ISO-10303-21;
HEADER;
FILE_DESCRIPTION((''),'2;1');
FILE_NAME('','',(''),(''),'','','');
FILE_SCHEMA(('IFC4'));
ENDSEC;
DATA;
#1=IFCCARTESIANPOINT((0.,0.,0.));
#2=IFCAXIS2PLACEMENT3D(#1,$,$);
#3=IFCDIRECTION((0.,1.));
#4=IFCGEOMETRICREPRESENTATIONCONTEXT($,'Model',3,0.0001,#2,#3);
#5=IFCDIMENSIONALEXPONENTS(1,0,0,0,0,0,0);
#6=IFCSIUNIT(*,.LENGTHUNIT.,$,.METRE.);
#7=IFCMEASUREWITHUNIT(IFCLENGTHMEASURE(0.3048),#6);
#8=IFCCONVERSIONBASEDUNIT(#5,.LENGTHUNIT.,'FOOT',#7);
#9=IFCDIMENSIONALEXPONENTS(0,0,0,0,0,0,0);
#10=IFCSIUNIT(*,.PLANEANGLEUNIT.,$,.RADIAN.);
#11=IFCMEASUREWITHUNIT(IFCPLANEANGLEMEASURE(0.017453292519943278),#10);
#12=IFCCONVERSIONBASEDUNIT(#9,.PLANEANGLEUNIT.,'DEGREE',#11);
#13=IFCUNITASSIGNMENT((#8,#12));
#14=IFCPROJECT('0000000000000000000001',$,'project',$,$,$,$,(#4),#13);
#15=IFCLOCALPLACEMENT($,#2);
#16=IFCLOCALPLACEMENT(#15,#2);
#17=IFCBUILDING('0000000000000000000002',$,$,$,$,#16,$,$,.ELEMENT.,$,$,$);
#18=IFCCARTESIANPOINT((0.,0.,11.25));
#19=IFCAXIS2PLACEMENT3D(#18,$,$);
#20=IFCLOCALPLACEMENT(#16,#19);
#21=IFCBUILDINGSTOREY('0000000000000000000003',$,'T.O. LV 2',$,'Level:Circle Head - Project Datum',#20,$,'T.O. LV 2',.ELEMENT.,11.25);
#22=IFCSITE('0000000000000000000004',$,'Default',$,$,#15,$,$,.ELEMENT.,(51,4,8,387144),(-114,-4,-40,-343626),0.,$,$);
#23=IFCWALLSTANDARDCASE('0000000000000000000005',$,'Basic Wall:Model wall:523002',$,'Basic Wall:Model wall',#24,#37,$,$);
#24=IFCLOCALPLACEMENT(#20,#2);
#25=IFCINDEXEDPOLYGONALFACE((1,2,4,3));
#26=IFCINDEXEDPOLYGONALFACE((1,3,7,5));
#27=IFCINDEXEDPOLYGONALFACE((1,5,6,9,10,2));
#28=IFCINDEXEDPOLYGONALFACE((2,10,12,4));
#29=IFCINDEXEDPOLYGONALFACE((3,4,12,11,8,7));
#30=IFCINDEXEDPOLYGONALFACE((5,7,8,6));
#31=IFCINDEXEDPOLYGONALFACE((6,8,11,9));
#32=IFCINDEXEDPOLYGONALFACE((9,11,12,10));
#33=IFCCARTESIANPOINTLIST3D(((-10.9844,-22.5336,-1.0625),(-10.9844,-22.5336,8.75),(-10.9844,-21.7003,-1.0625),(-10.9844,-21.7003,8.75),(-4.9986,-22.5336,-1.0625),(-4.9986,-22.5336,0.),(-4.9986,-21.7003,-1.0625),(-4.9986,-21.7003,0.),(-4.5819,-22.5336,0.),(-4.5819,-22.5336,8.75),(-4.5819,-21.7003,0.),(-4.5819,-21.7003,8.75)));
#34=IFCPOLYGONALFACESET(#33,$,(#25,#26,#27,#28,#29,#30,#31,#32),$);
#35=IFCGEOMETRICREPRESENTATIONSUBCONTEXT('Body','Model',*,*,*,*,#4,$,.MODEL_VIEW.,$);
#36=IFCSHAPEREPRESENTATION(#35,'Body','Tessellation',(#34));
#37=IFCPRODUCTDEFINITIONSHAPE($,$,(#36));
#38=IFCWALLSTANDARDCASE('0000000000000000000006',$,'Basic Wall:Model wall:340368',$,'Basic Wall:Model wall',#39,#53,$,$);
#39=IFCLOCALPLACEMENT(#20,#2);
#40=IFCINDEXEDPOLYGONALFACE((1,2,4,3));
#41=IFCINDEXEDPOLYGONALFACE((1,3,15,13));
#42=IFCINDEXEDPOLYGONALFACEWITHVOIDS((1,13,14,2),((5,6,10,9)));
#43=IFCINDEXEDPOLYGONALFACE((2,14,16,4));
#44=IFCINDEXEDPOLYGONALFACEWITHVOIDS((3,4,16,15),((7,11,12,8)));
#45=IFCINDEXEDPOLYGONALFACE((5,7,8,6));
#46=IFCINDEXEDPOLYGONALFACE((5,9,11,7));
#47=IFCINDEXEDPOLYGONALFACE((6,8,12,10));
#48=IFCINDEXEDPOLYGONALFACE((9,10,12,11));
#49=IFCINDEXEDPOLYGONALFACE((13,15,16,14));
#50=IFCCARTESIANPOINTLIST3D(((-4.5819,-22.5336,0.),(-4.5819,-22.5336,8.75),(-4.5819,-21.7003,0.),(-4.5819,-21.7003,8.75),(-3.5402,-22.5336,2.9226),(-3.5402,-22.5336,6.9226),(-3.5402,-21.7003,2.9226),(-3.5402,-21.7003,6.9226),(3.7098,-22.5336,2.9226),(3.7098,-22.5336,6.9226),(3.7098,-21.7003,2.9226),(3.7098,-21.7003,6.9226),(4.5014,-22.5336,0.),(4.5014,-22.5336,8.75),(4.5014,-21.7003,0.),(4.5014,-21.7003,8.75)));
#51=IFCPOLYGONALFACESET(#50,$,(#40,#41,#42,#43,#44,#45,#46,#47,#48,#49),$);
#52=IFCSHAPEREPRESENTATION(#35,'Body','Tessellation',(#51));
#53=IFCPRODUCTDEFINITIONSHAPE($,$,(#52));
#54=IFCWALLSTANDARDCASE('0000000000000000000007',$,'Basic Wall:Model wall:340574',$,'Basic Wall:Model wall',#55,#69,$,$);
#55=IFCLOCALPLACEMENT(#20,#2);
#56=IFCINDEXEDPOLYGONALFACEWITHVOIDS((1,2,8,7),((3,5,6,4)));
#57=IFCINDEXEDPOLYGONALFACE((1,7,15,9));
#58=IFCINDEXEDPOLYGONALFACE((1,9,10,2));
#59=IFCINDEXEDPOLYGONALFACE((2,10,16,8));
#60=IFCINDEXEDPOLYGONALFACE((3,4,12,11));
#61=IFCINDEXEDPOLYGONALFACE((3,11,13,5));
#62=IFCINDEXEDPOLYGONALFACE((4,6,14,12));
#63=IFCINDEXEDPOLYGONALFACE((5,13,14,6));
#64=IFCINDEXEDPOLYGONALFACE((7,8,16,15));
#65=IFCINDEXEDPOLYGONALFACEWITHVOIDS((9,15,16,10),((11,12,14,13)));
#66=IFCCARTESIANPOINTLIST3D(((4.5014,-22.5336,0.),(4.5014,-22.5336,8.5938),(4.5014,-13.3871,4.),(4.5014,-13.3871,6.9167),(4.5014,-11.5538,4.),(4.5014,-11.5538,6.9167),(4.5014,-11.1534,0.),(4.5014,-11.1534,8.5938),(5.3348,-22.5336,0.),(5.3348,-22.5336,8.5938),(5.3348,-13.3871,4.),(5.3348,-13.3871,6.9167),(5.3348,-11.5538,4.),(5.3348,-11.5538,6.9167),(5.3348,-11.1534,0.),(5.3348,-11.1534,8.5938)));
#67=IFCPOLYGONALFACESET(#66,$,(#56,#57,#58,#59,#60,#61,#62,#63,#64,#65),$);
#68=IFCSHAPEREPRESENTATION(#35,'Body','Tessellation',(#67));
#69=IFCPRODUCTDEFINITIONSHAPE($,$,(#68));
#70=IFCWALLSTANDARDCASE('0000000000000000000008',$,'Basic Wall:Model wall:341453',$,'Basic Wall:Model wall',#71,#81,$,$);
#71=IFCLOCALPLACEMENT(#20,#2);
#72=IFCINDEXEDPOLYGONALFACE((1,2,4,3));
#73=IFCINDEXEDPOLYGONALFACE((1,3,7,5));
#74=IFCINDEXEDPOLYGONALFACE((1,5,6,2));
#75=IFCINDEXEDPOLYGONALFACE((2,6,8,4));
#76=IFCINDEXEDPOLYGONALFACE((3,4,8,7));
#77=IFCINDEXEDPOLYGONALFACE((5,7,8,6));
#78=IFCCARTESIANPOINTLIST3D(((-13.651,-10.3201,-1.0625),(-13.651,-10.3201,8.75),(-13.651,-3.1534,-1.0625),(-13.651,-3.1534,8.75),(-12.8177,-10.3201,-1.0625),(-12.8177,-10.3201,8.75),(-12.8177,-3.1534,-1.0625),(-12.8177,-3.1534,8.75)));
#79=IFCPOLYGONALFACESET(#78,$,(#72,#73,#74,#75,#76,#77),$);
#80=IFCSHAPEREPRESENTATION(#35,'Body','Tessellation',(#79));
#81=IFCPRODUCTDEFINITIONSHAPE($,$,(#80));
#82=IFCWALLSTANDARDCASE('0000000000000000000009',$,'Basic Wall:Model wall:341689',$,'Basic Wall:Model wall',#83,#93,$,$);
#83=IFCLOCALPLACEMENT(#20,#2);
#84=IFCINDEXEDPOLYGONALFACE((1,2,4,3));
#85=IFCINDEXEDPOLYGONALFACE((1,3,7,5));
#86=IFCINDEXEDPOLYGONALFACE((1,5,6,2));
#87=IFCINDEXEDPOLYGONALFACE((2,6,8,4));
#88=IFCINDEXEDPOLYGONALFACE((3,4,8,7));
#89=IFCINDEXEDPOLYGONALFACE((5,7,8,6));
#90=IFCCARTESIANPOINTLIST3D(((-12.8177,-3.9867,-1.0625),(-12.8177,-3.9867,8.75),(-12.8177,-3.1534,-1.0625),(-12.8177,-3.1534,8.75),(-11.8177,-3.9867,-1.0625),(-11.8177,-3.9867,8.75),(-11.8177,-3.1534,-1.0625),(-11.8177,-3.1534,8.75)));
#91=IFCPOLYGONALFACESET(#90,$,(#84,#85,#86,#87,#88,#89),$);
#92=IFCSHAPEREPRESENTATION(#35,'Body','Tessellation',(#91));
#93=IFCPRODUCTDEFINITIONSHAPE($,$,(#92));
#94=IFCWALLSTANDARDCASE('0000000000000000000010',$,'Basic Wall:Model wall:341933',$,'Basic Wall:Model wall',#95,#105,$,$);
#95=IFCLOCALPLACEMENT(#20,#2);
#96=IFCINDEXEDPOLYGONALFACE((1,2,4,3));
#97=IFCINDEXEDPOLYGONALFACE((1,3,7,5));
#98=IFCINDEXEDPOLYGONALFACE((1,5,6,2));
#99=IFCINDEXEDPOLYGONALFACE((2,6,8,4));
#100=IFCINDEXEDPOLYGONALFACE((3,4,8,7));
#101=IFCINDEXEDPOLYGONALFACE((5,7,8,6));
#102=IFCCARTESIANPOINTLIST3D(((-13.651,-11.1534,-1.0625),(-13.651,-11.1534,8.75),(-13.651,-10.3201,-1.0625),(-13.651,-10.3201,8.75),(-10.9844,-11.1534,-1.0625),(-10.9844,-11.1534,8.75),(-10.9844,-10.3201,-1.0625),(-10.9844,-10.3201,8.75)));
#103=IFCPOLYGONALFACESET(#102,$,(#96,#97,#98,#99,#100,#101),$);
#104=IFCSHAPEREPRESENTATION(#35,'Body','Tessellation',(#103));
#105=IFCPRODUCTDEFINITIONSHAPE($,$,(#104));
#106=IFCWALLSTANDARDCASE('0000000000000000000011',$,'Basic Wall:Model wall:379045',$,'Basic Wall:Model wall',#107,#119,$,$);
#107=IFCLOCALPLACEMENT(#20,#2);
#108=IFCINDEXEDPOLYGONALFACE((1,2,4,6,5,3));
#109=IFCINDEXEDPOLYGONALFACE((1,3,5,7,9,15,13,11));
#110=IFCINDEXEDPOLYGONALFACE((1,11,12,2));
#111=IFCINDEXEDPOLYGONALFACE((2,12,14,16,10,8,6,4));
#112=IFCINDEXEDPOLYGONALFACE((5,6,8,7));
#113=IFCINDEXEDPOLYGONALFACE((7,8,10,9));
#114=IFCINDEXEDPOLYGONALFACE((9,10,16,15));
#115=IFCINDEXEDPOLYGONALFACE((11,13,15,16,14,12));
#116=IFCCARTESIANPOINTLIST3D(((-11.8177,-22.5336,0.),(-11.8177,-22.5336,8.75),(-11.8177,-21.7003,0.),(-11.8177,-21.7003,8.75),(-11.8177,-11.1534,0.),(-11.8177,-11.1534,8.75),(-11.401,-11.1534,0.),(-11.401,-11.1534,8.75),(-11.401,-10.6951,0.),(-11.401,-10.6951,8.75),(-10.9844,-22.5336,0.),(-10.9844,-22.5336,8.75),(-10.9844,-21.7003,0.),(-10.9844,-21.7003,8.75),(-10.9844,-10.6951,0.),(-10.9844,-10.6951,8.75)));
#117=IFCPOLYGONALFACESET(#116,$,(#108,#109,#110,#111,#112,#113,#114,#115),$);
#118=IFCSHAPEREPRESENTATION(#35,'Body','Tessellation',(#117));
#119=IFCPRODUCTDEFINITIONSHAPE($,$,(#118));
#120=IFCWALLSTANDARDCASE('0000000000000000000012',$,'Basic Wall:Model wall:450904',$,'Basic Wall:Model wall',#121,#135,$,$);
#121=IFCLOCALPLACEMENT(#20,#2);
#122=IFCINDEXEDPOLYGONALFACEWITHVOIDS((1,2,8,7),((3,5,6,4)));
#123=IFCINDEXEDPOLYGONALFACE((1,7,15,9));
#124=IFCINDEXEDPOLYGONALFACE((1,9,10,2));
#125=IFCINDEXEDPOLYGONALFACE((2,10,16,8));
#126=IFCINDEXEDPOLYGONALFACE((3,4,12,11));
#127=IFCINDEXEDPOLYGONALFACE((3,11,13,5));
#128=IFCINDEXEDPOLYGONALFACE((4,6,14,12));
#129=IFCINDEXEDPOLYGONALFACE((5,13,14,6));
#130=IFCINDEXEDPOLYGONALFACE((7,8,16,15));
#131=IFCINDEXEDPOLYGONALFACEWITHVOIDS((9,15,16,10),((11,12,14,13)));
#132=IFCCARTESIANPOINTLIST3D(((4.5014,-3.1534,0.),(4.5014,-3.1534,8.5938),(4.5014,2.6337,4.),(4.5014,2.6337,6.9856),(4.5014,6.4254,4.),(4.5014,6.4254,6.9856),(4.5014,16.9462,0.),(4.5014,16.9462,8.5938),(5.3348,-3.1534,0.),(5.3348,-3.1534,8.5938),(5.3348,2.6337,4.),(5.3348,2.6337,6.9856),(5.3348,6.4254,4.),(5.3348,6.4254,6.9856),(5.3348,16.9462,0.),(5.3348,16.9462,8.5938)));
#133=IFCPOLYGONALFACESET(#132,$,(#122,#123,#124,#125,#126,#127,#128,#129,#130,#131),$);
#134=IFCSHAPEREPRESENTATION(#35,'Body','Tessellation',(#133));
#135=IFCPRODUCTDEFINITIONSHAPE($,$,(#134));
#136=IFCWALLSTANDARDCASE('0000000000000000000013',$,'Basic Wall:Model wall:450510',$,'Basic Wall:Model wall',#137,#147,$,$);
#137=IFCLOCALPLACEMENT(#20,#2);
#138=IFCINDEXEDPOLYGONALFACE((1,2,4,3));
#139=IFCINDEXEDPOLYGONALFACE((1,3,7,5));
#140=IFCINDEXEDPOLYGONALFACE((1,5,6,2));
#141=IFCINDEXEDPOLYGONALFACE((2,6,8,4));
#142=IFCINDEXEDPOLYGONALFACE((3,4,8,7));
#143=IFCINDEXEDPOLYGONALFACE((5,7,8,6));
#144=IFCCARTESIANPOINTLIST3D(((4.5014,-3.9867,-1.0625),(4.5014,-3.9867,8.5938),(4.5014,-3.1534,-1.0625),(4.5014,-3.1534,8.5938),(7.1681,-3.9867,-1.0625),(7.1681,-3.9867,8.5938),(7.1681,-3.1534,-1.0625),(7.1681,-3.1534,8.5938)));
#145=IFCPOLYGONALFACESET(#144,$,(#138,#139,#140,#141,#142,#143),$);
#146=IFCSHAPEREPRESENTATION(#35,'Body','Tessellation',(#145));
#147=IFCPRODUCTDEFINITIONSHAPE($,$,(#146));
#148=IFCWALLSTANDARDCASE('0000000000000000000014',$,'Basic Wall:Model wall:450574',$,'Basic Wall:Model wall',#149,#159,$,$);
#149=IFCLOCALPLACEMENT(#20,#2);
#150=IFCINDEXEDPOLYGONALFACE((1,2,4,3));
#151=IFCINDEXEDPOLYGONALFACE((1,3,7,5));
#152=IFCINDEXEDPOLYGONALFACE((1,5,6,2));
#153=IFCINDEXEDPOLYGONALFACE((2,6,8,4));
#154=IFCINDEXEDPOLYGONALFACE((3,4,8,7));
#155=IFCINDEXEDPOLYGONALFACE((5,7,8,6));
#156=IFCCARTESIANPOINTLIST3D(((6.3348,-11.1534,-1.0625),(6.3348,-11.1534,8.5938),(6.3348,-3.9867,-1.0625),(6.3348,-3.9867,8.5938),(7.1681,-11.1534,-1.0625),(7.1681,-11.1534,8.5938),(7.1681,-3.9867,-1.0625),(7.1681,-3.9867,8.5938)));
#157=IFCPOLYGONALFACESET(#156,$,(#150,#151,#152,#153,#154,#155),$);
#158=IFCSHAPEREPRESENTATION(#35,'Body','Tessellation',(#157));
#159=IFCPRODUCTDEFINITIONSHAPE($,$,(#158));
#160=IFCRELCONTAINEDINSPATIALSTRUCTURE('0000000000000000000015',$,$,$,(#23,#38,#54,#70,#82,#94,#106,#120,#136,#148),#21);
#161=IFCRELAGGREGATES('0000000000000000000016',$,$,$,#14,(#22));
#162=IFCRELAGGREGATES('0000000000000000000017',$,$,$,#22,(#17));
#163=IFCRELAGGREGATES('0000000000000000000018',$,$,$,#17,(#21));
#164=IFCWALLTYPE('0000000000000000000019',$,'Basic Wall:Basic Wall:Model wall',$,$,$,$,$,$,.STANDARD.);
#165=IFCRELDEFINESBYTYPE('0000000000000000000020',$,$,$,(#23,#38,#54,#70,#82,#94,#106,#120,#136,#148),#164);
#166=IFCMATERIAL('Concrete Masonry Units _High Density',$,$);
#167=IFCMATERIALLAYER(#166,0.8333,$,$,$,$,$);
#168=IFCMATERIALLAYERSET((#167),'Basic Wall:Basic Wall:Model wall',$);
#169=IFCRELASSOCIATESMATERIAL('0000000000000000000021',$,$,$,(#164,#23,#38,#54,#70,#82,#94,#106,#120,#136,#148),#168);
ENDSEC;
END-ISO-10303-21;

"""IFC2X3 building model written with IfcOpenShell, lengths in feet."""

from ifc_helpers import new_model, entity, si_unit, converted_unit, direction, frame, frame_2d, origin, place, context, subcontext, project, spatial, polyline, rectangle, outline, extrude, material, layer, layer_set, layer_usage, type_object, element, save


model = new_model("IFC2X3")

# Units and contexts
model_context = context("Model", 3, precision=0.0001, world=origin(), true_north=direction((0.0, 1.0)))
body_context = subcontext(model_context, "Body", "Model", "MODEL_VIEW")
ifc_project = project(units=[converted_unit("LENGTHUNIT", "FOOT", entity("IfcLengthMeasure", 0.3048), si_unit("LENGTHUNIT", "METRE"), dimensions=[1, 0, 0, 0, 0, 0, 0]), converted_unit("PLANEANGLEUNIT", "DEGREE", entity("IfcPlaneAngleMeasure", 0.017453292519943278), si_unit("PLANEANGLEUNIT", "RADIAN"), dimensions=[0, 0, 0, 0, 0, 0, 0])], contexts=[model_context])

# Site, building, storey
site_placement = place(None, origin())
site = spatial("IfcSite", under=ifc_project, at=site_placement, Name="Default", CompositionType="ELEMENT", RefLatitude=(51, 4, 8, 387144), RefLongitude=(-114, -4, -40, -343626), RefElevation=0.0)
building_placement = place(site_placement, origin())
building = spatial("IfcBuilding", under=site, at=building_placement, CompositionType="ELEMENT")
storey_placement = place(building_placement, frame((0.0, 0.0, 11.25)))
storey = spatial("IfcBuildingStorey", under=building, at=storey_placement, Name="T.O. LV 2", ObjectType="Level:Circle Head - Project Datum", LongName="T.O. LV 2", CompositionType="ELEMENT", Elevation=11.25)

# Wall, openings
ifc_material_1 = material(Name="Concrete Masonry Units _High Density")
ifc_layer_1 = layer(ifc_material_1, 0.8333)
ifc_layer_set_1 = layer_set([ifc_layer_1], Name="Basic Wall:Basic Wall:Model wall")
ifc_layer_usage_1 = layer_usage(ifc_layer_set_1, "AXIS2", "NEGATIVE", 0.4167)
wall_type_1 = type_object("IfcWallType", Name="Basic Wall:Basic Wall:Model wall", PredefinedType="STANDARD", material=ifc_layer_set_1)
wall_1_placement = place(storey_placement, frame((-4.5819, -22.117, -1.0625), z_axis=(0.0, 0.0, 1.0), x_axis=(-1.0, 0.0, 0.0)))
wall_1 = element("IfcWallStandardCase", 1, at=wall_1_placement, inside=storey, type_object=wall_type_1, material=ifc_layer_usage_1, Name="Basic Wall:Model wall:523002", ObjectType="Basic Wall:Model wall", context=body_context, shape_type="SweptSolid", body=[
    extrude(rectangle(XDim=6.4025, YDim=0.8333, at=frame_2d((3.2012, 0.0), x_axis=(-1.0, 0.0))), origin(), (0.0, 0.0, 1.0), 9.8125),
])
opening_1_placement = place(wall_1_placement, origin())
element("IfcOpeningElement", 2, at=opening_1_placement, cuts=wall_1, ObjectType="Opening", context=body_context, shape_type="SweptSolid", body=[
    extrude(rectangle(XDim=1.0625, YDim=0.4167, at=frame_2d((0.0, 0.0), x_axis=(1.0, 0.0))), frame((0.2083, -0.4167, 0.5312), z_axis=(0.0, 1.0, 0.0), x_axis=(0.0, 0.0, -1.0)), (0.0, 0.0, 1.0), 0.8333),
])
opening_2_placement = place(wall_1_placement, origin())
element("IfcOpeningElement", 3, at=opening_2_placement, cuts=wall_1, ObjectType="Opening", context=body_context, shape_type="SweptSolid", body=[
    extrude(rectangle(XDim=1.0625, YDim=0.4167, at=frame_2d((0.0, 0.0), x_axis=(1.0, 0.0))), frame((6.6108, -0.4167, 0.5312), z_axis=(0.0, 1.0, 0.0), x_axis=(0.0, 0.0, -1.0)), (0.0, 0.0, 1.0), 0.8333),
])

# Walls, openings
ifc_layer_usage_2 = layer_usage(ifc_layer_set_1, "AXIS2", "NEGATIVE", 0.4167)
wall_2_placement = place(storey_placement, frame((4.5014, -22.117, 0.0), z_axis=(0.0, 0.0, 1.0), x_axis=(-1.0, 0.0, 0.0)))
wall_2 = element("IfcWallStandardCase", 4, at=wall_2_placement, inside=storey, type_object=wall_type_1, material=ifc_layer_usage_2, Name="Basic Wall:Model wall:340368", ObjectType="Basic Wall:Model wall", context=body_context, shape_type="SweptSolid", body=[
    extrude(rectangle(XDim=9.0833, YDim=0.8333, at=frame_2d((4.5417, 0.0), x_axis=(-1.0, 0.0))), origin(), (0.0, 0.0, 1.0), 8.75),
])
opening_3_placement = place(wall_2_placement, frame((4.5014, -22.117, 0.0), z_axis=(0.0, 0.0, 1.0), x_axis=(-1.0, 0.0, 0.0)))
element("IfcOpeningElement", 5, at=opening_3_placement, cuts=wall_2, ObjectType="Opening", context=body_context, shape_type="SweptSolid", body=[
    extrude(rectangle(XDim=4.0, YDim=7.25, at=frame_2d((0.0, 0.0), x_axis=(0.0, 1.0))), frame((0.0848, -21.692, 4.9226), z_axis=(0.0, -1.0, 0.0), x_axis=(1.0, 0.0, 0.0)), (0.0, 0.0, 1.0), 0.85),
])
ifc_layer_usage_3 = layer_usage(ifc_layer_set_1, "AXIS2", "NEGATIVE", 0.4167)
wall_3_placement = place(storey_placement, frame((4.9181, -22.5336, 0.0), z_axis=(0.0, 0.0, 1.0), x_axis=(0.0, 1.0, 0.0)))
wall_3 = element("IfcWallStandardCase", 6, at=wall_3_placement, inside=storey, type_object=wall_type_1, material=ifc_layer_usage_3, Name="Basic Wall:Model wall:340574", ObjectType="Basic Wall:Model wall", context=body_context, shape_type="SweptSolid", body=[
    extrude(rectangle(XDim=11.3802, YDim=0.8333, at=frame_2d((5.6901, 0.0), x_axis=(-1.0, 0.0))), origin(), (0.0, 0.0, 1.0), 8.5938),
])
opening_4_placement = place(wall_3_placement, frame((22.5336, 4.9181, 0.0), z_axis=(0.0, 0.0, 1.0), x_axis=(0.0, -1.0, 0.0)))
element("IfcOpeningElement", 7, at=opening_4_placement, cuts=wall_3, ObjectType="Opening", context=body_context, shape_type="SweptSolid", body=[
    extrude(rectangle(XDim=2.9167, YDim=1.8333, at=frame_2d((0.0, 0.0), x_axis=(1.0, 0.0))), frame((5.3431, -12.4705, 5.4583), z_axis=(-1.0, 0.0, 0.0), x_axis=(0.0, 0.0, 1.0)), (0.0, 0.0, 1.0), 0.85),
])

# Walls
ifc_layer_usage_4 = layer_usage(ifc_layer_set_1, "AXIS2", "NEGATIVE", 0.4167)
wall_4_placement = place(storey_placement, frame((-13.2344, -3.1534, -1.0625), z_axis=(0.0, 0.0, 1.0), x_axis=(0.0, -1.0, 0.0)))
element("IfcWallStandardCase", 8, at=wall_4_placement, inside=storey, type_object=wall_type_1, material=ifc_layer_usage_4, Name="Basic Wall:Model wall:341453", ObjectType="Basic Wall:Model wall", context=body_context, shape_type="SweptSolid", body=[
    extrude(rectangle(XDim=7.1667, YDim=0.8333, at=frame_2d((3.5833, 0.0), x_axis=(-1.0, 0.0))), origin(), (0.0, 0.0, 1.0), 9.8125),
])
ifc_layer_usage_5 = layer_usage(ifc_layer_set_1, "AXIS2", "NEGATIVE", 0.4167)
wall_5_placement = place(storey_placement, frame((-12.8177, -3.5701, -1.0625)))
element("IfcWallStandardCase", 9, at=wall_5_placement, inside=storey, type_object=wall_type_1, material=ifc_layer_usage_5, Name="Basic Wall:Model wall:341689", ObjectType="Basic Wall:Model wall", context=body_context, shape_type="SweptSolid", body=[
    extrude(rectangle(XDim=1.0, YDim=0.8333, at=frame_2d((0.5, 0.0), x_axis=(-1.0, 0.0))), origin(), (0.0, 0.0, 1.0), 9.8125),
])
ifc_layer_usage_6 = layer_usage(ifc_layer_set_1, "AXIS2", "NEGATIVE", 0.4167)
wall_6_placement = place(storey_placement, frame((-13.651, -10.7367, -1.0625)))
element("IfcWallStandardCase", 10, at=wall_6_placement, inside=storey, type_object=wall_type_1, material=ifc_layer_usage_6, Name="Basic Wall:Model wall:341933", ObjectType="Basic Wall:Model wall", context=body_context, shape_type="SweptSolid", body=[
    extrude(rectangle(XDim=2.6667, YDim=0.8333, at=frame_2d((1.3333, 0.0), x_axis=(-1.0, 0.0))), origin(), (0.0, 0.0, 1.0), 9.8125),
])
ifc_layer_usage_7 = layer_usage(ifc_layer_set_1, "AXIS2", "NEGATIVE", 0.4167)
wall_7_placement = place(storey_placement, frame((-11.401, -10.6951, 0.0), z_axis=(0.0, 0.0, 1.0), x_axis=(0.0, -1.0, 0.0)))
element("IfcWallStandardCase", 11, at=wall_7_placement, inside=storey, type_object=wall_type_1, material=ifc_layer_usage_7, Name="Basic Wall:Model wall:379045", ObjectType="Basic Wall:Model wall", context=body_context, shape_type="SweptSolid", body=[
    extrude(outline(polyline([(-0.4167, -6.013), (0.4167, -6.013), (0.4167, -5.1797), (0.4167, 5.8255), (0.0, 5.8255), (0.0, 5.3672), (-0.4167, 5.3672), (-0.4167, -5.1797), (-0.4167, -6.013)])), frame((5.8255, 0.0, 0.0), z_axis=(0.0, 0.0, 1.0), x_axis=(0.0, 1.0, 0.0)), (0.0, 0.0, 1.0), 8.75),
])

# Wall, opening
ifc_layer_usage_8 = layer_usage(ifc_layer_set_1, "AXIS2", "NEGATIVE", 0.4167)
wall_8_placement = place(storey_placement, frame((4.9181, -3.1534, 0.0), z_axis=(0.0, 0.0, 1.0), x_axis=(0.0, 1.0, 0.0)))
wall_8 = element("IfcWallStandardCase", 12, at=wall_8_placement, inside=storey, type_object=wall_type_1, material=ifc_layer_usage_8, Name="Basic Wall:Model wall:450904", ObjectType="Basic Wall:Model wall", context=body_context, shape_type="SweptSolid", body=[
    extrude(rectangle(XDim=20.0996, YDim=0.8333, at=frame_2d((10.0498, 0.0), x_axis=(-1.0, 0.0))), origin(), (0.0, 0.0, 1.0), 8.5938),
])
opening_5_placement = place(wall_8_placement, frame((3.1534, 4.9181, 0.0), z_axis=(0.0, 0.0, 1.0), x_axis=(0.0, -1.0, 0.0)))
element("IfcOpeningElement", 13, at=opening_5_placement, cuts=wall_8, ObjectType="Opening", context=body_context, shape_type="SweptSolid", body=[
    extrude(rectangle(XDim=2.9856, YDim=3.7917, at=frame_2d((0.0, 0.0), x_axis=(1.0, 0.0))), frame((5.3431, 4.5295, 5.4928), z_axis=(-1.0, 0.0, 0.0), x_axis=(0.0, 0.0, 1.0)), (0.0, 0.0, 1.0), 0.85),
])

# Walls
ifc_layer_usage_9 = layer_usage(ifc_layer_set_1, "AXIS2", "NEGATIVE", 0.4167)
wall_9_placement = place(storey_placement, frame((4.5014, -3.5701, -1.0625)))
element("IfcWallStandardCase", 14, at=wall_9_placement, inside=storey, type_object=wall_type_1, material=ifc_layer_usage_9, Name="Basic Wall:Model wall:450510", ObjectType="Basic Wall:Model wall", context=body_context, shape_type="SweptSolid", body=[
    extrude(rectangle(XDim=2.6667, YDim=0.8333, at=frame_2d((1.3333, 0.0), x_axis=(-1.0, 0.0))), origin(), (0.0, 0.0, 1.0), 9.6563),
])
ifc_layer_usage_10 = layer_usage(ifc_layer_set_1, "AXIS2", "NEGATIVE", 0.4167)
wall_10_placement = place(storey_placement, frame((6.7514, -3.9867, -1.0625), z_axis=(0.0, 0.0, 1.0), x_axis=(0.0, -1.0, 0.0)))
element("IfcWallStandardCase", 15, at=wall_10_placement, inside=storey, type_object=wall_type_1, material=ifc_layer_usage_10, Name="Basic Wall:Model wall:450574", ObjectType="Basic Wall:Model wall", context=body_context, shape_type="SweptSolid", body=[
    extrude(rectangle(XDim=7.1667, YDim=0.8333, at=frame_2d((3.5833, 0.0), x_axis=(-1.0, 0.0))), origin(), (0.0, 0.0, 1.0), 9.6563),
])

save(model, "model.ifc")
